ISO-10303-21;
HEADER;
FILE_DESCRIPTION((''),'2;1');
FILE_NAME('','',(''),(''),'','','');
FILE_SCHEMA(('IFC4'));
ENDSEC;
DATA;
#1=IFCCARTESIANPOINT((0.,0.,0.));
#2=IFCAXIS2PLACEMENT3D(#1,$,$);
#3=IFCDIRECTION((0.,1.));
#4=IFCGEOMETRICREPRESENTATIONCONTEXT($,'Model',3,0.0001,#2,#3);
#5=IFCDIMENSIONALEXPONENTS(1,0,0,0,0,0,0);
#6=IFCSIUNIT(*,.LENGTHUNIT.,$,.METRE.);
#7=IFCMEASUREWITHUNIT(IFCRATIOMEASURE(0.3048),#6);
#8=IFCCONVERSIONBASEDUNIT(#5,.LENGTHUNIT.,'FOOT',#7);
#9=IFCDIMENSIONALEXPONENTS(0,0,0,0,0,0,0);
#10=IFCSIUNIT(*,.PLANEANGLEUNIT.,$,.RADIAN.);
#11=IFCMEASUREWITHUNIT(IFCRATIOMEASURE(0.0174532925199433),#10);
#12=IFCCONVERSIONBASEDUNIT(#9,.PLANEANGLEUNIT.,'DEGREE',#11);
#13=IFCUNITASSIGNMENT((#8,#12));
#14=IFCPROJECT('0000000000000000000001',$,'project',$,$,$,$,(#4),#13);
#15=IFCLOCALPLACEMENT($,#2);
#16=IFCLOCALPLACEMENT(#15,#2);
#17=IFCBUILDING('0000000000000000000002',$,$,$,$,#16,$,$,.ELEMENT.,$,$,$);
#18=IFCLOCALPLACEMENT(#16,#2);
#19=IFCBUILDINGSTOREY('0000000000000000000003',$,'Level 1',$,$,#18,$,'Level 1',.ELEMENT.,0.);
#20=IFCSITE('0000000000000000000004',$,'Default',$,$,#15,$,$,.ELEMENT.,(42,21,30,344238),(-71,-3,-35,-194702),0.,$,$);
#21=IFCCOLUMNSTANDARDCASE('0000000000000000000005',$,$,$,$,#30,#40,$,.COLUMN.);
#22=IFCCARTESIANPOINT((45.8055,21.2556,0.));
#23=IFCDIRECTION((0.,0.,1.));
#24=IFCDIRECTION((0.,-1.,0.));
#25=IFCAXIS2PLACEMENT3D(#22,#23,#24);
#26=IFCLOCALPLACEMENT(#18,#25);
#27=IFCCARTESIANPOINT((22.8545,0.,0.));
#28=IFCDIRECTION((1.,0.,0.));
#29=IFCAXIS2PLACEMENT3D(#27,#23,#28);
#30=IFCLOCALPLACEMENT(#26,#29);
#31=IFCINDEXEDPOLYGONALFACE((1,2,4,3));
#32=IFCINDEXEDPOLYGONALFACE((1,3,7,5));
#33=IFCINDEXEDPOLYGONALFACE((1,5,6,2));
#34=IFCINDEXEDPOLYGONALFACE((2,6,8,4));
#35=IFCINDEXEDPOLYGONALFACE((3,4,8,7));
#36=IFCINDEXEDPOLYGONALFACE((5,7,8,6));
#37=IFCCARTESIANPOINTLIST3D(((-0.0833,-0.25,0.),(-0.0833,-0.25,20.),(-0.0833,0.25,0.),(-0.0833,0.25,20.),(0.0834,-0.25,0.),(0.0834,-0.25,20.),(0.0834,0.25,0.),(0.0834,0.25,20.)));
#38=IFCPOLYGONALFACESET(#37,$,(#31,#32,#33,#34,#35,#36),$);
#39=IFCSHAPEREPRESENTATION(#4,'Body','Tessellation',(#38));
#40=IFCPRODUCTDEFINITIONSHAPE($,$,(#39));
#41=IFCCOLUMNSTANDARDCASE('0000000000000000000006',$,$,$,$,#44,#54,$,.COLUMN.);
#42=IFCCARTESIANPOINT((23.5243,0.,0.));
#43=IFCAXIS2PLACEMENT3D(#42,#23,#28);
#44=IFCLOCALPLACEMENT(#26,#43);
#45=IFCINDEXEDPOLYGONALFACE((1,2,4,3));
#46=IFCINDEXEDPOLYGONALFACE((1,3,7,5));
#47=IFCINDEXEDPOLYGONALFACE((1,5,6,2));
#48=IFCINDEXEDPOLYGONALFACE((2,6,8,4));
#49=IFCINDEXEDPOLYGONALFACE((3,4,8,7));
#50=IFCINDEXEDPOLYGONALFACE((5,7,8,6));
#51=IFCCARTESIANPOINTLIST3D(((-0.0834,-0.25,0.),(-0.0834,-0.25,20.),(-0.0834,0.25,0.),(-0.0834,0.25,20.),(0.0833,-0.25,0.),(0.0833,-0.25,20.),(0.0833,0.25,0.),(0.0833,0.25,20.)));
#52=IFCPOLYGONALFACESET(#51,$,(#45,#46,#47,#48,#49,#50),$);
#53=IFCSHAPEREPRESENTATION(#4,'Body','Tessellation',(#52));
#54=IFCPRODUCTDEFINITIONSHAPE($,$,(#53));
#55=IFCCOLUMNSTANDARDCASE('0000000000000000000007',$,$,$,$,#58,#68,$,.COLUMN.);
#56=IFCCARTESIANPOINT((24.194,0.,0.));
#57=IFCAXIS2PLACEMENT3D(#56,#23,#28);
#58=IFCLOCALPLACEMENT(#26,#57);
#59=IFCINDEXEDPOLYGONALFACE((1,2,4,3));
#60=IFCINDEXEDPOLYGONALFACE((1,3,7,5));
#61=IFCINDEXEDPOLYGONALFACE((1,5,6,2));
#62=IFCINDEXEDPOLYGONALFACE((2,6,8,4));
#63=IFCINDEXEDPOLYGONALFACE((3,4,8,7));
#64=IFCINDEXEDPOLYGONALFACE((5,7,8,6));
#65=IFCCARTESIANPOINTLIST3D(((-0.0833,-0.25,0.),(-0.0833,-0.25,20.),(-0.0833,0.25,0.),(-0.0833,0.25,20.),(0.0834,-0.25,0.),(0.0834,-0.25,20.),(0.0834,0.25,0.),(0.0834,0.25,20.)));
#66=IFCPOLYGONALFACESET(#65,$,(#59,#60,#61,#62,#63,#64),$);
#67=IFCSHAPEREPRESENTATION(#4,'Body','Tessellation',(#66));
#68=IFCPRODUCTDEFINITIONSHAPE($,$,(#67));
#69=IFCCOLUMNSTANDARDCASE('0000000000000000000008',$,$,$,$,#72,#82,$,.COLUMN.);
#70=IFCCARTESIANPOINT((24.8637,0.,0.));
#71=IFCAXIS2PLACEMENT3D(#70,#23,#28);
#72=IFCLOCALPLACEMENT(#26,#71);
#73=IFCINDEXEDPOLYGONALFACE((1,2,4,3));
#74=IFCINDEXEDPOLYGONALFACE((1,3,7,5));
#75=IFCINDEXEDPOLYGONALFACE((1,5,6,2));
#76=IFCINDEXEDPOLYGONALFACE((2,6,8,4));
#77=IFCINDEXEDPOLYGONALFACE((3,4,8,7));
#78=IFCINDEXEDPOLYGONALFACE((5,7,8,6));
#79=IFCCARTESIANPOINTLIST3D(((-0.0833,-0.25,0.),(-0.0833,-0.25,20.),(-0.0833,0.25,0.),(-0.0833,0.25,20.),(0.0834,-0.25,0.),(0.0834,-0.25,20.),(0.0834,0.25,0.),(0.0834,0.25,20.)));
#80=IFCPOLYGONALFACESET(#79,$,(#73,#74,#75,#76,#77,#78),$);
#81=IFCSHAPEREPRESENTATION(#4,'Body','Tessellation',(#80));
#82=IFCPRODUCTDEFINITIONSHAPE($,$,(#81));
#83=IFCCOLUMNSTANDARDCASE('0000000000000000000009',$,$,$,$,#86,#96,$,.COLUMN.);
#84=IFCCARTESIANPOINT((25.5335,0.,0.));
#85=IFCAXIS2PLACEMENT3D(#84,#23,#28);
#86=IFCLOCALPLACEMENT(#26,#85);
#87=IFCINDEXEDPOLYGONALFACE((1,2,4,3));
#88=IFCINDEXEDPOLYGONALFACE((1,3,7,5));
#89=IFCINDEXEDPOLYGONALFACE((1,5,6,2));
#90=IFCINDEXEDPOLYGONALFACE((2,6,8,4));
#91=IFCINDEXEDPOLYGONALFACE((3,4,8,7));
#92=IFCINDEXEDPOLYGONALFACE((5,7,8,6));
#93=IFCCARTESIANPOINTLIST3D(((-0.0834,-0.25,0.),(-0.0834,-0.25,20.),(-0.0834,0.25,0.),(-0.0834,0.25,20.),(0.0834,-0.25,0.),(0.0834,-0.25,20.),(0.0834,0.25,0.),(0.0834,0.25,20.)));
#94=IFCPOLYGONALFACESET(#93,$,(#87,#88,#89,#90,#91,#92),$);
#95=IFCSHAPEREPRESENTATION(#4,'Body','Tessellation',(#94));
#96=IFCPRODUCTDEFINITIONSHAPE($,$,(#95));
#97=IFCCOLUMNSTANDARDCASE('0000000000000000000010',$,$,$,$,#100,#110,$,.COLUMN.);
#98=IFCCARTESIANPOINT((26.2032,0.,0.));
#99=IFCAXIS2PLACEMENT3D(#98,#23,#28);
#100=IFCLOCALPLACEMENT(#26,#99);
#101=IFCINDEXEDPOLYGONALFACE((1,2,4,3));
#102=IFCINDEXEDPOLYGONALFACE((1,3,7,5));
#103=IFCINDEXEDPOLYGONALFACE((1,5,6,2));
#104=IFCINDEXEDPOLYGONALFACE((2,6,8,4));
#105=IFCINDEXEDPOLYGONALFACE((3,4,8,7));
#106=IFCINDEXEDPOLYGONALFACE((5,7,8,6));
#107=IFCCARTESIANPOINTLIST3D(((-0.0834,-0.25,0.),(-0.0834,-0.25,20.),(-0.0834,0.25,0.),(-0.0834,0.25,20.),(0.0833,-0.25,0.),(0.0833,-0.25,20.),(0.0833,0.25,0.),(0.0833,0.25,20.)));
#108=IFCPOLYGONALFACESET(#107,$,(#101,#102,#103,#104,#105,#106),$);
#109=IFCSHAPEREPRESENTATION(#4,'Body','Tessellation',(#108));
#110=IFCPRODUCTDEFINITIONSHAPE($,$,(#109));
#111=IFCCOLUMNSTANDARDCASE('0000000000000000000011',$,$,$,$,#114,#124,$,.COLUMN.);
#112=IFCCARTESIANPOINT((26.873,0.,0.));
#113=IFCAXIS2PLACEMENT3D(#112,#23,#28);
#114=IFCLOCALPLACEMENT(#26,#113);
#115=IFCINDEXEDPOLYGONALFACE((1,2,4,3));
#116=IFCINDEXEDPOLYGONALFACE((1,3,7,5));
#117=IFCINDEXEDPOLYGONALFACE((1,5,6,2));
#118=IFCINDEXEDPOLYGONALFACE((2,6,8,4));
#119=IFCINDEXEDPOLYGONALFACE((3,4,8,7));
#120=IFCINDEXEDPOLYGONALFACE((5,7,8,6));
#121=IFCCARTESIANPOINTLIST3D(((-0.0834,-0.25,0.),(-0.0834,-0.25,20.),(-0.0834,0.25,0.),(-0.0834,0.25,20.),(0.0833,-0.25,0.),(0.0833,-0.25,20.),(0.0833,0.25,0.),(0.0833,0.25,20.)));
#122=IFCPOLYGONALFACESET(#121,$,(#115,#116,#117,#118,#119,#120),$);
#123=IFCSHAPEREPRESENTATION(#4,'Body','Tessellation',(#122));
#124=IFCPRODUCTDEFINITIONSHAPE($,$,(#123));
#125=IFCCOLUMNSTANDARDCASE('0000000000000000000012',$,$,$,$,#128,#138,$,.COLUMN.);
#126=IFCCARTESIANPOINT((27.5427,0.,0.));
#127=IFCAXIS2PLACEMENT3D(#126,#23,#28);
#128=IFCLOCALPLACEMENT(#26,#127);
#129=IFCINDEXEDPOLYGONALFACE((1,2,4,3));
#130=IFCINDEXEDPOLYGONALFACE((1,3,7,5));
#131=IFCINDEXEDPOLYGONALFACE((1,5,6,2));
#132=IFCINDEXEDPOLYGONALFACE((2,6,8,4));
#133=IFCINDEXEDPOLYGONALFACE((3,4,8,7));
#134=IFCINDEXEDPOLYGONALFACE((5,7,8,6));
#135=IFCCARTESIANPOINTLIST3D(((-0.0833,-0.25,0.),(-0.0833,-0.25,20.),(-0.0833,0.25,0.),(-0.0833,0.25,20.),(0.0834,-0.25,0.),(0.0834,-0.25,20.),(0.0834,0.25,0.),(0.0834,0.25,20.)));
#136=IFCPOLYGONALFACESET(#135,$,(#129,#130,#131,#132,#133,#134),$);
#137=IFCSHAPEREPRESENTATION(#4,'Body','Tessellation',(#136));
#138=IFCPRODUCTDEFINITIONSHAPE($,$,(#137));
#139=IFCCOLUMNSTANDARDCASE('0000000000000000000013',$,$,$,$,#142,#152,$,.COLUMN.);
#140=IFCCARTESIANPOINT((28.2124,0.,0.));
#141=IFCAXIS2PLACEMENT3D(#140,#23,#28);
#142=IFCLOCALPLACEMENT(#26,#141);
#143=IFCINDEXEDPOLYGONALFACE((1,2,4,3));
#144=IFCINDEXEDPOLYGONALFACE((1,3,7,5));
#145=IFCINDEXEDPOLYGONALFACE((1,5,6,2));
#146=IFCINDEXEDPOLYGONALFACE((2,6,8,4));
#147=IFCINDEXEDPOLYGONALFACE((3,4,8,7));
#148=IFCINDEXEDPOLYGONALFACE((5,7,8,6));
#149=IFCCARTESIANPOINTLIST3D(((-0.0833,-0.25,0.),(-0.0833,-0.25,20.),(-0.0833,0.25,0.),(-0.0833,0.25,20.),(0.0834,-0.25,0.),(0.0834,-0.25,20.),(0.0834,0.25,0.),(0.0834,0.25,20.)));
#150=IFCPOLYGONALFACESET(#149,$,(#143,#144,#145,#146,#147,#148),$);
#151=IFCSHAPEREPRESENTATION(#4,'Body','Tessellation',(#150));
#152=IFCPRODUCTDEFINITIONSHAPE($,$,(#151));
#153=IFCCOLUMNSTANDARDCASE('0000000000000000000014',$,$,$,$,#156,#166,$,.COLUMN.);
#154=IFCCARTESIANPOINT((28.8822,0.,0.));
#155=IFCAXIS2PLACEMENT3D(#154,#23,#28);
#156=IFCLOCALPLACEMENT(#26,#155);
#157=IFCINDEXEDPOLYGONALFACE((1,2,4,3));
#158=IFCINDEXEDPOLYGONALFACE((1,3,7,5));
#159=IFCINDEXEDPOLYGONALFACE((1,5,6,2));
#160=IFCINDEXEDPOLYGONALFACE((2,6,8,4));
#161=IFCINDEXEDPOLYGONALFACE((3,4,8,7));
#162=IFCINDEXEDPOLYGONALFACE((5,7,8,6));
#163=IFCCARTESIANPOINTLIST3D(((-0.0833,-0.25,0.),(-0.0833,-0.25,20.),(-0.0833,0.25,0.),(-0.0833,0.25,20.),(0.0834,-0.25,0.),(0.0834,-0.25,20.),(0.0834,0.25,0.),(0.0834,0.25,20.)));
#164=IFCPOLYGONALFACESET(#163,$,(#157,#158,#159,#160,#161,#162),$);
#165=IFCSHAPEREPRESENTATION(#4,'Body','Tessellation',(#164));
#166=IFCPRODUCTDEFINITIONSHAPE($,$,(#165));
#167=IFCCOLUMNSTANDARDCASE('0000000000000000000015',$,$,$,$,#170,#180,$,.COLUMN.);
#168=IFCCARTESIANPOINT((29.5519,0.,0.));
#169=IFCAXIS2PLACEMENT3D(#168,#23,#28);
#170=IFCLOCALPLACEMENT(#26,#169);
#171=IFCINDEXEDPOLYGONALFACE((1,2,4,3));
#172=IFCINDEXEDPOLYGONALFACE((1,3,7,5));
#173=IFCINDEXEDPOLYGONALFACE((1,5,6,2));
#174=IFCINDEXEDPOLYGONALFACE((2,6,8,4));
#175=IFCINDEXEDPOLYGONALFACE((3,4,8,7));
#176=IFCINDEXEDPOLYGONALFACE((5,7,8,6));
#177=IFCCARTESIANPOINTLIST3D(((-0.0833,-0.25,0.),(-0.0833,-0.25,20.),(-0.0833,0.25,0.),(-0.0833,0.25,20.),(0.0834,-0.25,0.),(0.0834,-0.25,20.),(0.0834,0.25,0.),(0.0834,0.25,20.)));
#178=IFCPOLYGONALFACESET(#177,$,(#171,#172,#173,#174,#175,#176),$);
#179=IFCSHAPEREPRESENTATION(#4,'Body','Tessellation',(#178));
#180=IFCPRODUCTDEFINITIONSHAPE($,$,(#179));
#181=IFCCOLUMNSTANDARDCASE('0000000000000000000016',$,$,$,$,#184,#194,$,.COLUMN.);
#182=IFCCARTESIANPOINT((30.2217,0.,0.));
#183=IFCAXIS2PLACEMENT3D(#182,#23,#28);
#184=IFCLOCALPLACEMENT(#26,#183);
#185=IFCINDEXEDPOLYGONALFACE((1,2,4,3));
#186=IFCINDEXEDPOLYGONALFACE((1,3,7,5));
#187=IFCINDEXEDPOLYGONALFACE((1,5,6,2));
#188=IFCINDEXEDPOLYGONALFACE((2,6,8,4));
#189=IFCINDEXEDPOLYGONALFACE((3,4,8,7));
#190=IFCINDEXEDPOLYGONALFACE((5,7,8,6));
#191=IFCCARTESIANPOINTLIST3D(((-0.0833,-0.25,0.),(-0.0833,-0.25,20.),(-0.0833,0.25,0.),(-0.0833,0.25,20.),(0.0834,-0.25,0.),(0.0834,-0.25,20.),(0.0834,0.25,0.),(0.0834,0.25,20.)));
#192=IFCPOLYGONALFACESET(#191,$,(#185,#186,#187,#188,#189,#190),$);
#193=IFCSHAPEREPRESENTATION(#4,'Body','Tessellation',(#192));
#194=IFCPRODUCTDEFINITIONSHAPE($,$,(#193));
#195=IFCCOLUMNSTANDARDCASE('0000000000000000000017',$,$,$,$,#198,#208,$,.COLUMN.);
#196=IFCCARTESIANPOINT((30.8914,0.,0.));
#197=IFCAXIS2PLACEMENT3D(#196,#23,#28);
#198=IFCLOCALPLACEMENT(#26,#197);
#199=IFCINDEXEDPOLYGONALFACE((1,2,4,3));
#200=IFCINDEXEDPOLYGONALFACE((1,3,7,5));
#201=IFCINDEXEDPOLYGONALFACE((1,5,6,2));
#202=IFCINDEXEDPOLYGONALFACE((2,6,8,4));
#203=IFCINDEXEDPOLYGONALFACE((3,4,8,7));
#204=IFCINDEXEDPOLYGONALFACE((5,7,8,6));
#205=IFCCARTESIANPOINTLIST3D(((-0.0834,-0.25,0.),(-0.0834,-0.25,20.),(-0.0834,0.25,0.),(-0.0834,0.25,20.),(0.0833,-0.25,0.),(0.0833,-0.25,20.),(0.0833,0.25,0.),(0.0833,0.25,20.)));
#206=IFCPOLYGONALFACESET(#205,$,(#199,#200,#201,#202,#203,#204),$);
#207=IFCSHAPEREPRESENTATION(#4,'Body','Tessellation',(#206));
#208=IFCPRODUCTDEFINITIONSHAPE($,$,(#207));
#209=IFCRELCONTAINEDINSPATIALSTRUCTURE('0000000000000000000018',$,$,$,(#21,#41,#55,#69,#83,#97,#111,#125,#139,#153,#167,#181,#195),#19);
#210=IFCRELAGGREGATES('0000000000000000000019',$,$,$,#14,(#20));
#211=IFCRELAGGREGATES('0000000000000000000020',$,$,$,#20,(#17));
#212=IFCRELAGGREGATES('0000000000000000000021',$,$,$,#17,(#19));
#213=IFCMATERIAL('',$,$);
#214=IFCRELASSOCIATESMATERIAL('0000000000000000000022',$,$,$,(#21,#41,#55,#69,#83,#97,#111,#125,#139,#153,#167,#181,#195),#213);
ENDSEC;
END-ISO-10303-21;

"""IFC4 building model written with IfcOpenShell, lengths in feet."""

from ifc_helpers import new_model, entity, si_unit, converted_unit, direction, frame, origin, place, context, project, spatial, rectangle, extrude, material, element, save


model = new_model("IFC4")

# Units and contexts
model_context = context("Model", 3, precision=0.0001, world=origin(), true_north=direction((0.0, 1.0)))
ifc_project = project(units=[converted_unit("LENGTHUNIT", "FOOT", entity("IfcRatioMeasure", 0.3048), si_unit("LENGTHUNIT", "METRE"), dimensions=[1, 0, 0, 0, 0, 0, 0]), converted_unit("PLANEANGLEUNIT", "DEGREE", entity("IfcRatioMeasure", 0.0174532925199433), si_unit("PLANEANGLEUNIT", "RADIAN"), dimensions=[0, 0, 0, 0, 0, 0, 0])], contexts=[model_context])

# Site, building, storey
site_placement = place(None, origin())
site = spatial("IfcSite", under=ifc_project, at=site_placement, Name="Default", CompositionType="ELEMENT", RefLatitude=(42, 21, 30, 344238), RefLongitude=(-71, -3, -35, -194702), RefElevation=0.0)
building_placement = place(site_placement, origin())
building = spatial("IfcBuilding", under=site, at=building_placement, CompositionType="ELEMENT")
storey_placement = place(building_placement, origin())
storey = spatial("IfcBuildingStorey", under=building, at=storey_placement, Name="Level 1", LongName="Level 1", CompositionType="ELEMENT", Elevation=0.0)

# Columns
ifc_material = material(Name="")
placement = place(storey_placement, frame((45.8055, 21.2556, 0.0), z_axis=(0.0, 0.0, 1.0), x_axis=(0.0, -1.0, 0.0)))
for number, where, z_axis, x_axis in (
    (1, (22.8545, 0.0, 0.0), (0.0, 0.0, 1.0), (1.0, 0.0, 0.0)),
    (2, (23.5243, 0.0, 0.0), (0.0, 0.0, 1.0), (1.0, 0.0, 0.0)),
    (3, (24.194, 0.0, 0.0), (0.0, 0.0, 1.0), (1.0, 0.0, 0.0)),
    (4, (24.8637, 0.0, 0.0), (0.0, 0.0, 1.0), (1.0, 0.0, 0.0)),
    (5, (25.5335, 0.0, 0.0), (0.0, 0.0, 1.0), (1.0, 0.0, 0.0)),
    (6, (26.2032, 0.0, 0.0), (0.0, 0.0, 1.0), (1.0, 0.0, 0.0)),
    (7, (26.873, 0.0, 0.0), (0.0, 0.0, 1.0), (1.0, 0.0, 0.0)),
    (8, (27.5427, 0.0, 0.0), (0.0, 0.0, 1.0), (1.0, 0.0, 0.0)),
    (9, (28.2124, 0.0, 0.0), (0.0, 0.0, 1.0), (1.0, 0.0, 0.0)),
    (10, (28.8822, 0.0, 0.0), (0.0, 0.0, 1.0), (1.0, 0.0, 0.0)),
    (11, (29.5519, 0.0, 0.0), (0.0, 0.0, 1.0), (1.0, 0.0, 0.0)),
    (12, (30.2217, 0.0, 0.0), (0.0, 0.0, 1.0), (1.0, 0.0, 0.0)),
    (13, (30.8914, 0.0, 0.0), (0.0, 0.0, 1.0), (1.0, 0.0, 0.0)),
):
    element("IfcColumnStandardCase", number, at=place(placement, frame(where, z_axis=z_axis, x_axis=x_axis)), inside=storey, material=ifc_material, PredefinedType="COLUMN", context=model_context, shape_type="SweptSolid", body=[
        extrude(rectangle(XDim=0.1667, YDim=0.5), origin(), (0.0, 0.0, 1.0), 20.0),
    ])

save(model, "model.ifc")
